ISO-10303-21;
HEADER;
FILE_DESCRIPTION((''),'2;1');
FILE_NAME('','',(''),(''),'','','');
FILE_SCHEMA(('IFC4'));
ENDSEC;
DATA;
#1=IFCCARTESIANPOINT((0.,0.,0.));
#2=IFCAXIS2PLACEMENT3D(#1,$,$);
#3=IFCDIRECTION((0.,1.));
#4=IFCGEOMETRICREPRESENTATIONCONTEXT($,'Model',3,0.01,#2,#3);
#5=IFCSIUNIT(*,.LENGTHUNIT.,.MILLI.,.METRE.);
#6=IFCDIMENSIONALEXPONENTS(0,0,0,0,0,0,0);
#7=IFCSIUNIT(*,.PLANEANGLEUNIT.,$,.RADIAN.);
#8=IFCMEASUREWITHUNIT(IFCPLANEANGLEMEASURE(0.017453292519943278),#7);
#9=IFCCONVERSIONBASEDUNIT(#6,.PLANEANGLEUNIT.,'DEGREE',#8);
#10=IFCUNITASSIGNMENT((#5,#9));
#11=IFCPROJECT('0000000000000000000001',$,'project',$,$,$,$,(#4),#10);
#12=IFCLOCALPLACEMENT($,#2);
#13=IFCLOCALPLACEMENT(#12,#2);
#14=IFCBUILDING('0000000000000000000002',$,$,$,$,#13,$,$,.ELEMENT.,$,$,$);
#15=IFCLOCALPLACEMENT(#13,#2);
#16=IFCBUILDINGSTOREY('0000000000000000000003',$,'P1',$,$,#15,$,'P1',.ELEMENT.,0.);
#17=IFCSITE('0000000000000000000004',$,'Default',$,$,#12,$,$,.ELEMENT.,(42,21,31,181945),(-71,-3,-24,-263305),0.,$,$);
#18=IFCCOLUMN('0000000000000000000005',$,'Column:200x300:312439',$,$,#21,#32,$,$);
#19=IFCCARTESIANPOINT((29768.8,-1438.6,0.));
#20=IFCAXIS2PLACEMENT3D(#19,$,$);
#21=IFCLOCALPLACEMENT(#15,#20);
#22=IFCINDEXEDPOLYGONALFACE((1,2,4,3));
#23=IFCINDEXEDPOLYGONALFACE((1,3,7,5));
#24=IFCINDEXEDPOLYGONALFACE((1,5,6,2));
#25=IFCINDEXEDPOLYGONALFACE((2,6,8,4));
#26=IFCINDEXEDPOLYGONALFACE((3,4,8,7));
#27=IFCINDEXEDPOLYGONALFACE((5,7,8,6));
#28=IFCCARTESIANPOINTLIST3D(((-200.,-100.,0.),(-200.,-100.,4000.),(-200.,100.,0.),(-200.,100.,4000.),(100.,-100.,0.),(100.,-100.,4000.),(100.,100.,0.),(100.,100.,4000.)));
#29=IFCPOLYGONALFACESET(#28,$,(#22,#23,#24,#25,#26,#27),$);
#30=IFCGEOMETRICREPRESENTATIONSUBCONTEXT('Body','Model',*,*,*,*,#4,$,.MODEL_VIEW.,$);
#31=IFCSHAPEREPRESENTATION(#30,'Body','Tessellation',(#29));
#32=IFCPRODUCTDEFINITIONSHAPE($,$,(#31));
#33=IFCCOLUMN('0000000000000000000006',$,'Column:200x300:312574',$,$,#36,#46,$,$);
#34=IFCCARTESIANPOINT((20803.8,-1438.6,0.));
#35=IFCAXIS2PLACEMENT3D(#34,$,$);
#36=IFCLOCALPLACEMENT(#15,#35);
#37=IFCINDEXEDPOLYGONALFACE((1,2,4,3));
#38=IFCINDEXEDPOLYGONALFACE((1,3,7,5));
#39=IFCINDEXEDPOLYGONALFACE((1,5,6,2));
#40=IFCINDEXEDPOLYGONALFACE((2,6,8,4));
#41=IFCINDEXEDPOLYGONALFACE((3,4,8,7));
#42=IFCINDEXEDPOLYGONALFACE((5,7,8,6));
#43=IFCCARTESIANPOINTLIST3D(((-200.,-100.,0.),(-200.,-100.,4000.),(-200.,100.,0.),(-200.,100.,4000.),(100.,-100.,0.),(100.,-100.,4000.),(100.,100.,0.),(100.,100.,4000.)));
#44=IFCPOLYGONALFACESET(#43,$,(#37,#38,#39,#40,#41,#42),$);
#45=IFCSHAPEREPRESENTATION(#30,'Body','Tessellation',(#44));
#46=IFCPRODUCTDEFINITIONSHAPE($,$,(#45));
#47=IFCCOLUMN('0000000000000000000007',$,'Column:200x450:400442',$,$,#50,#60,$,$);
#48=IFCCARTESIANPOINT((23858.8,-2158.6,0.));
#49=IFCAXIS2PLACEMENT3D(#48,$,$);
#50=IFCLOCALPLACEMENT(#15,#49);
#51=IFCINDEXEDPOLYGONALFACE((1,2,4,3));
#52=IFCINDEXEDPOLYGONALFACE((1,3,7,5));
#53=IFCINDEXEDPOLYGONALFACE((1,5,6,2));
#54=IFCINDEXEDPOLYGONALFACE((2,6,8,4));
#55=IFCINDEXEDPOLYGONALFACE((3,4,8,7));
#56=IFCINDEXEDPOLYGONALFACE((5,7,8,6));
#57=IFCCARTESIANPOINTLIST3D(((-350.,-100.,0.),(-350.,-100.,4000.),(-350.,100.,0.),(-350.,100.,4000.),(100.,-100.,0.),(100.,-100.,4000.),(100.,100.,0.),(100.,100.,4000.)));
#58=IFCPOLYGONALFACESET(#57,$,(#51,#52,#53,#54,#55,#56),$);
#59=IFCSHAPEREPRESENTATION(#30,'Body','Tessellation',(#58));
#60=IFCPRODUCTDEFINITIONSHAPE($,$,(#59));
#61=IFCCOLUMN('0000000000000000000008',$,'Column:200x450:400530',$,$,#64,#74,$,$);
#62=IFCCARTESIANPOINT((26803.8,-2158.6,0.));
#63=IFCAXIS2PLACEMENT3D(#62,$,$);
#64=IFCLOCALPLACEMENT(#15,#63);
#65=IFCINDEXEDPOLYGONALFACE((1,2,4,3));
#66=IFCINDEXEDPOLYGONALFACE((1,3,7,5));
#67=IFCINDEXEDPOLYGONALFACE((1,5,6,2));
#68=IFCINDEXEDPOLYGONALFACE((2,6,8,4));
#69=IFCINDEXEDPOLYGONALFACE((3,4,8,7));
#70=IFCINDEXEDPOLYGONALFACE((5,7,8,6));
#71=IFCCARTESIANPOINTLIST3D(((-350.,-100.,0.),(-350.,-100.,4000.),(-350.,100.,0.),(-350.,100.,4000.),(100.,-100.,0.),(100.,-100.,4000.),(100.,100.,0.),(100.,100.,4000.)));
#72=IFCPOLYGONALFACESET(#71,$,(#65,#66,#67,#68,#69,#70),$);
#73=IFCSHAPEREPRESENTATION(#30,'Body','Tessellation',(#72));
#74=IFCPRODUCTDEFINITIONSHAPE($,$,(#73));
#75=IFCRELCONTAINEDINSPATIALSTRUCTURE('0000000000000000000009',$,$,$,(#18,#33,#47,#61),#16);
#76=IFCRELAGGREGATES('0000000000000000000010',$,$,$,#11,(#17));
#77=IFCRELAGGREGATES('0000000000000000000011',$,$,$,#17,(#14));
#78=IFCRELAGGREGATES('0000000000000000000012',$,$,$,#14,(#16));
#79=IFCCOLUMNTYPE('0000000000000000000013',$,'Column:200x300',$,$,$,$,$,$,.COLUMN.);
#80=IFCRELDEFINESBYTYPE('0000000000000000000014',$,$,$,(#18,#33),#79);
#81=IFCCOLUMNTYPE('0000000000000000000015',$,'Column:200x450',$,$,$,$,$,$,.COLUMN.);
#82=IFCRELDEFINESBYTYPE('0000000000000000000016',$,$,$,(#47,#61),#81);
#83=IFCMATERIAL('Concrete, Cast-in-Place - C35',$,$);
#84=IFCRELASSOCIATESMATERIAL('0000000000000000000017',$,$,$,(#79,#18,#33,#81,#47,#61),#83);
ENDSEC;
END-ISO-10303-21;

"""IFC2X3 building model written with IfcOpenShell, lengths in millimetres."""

from ifc_helpers import new_model, entity, si_unit, converted_unit, direction, frame, origin, origin_2d_with_axis, place, context, subcontext, project, spatial, rectangle, extrude, source, transform, mapped, material, type_object, type_shapes, element, save


model = new_model("IFC2X3")

# Units and contexts
model_context = context("Model", 3, precision=0.01, world=origin(), true_north=direction((0.0, 1.0)))
body_context = subcontext(model_context, "Body", "Model", "MODEL_VIEW")
ifc_project = project(units=[si_unit("LENGTHUNIT", "METRE", prefix="MILLI"), converted_unit("PLANEANGLEUNIT", "DEGREE", entity("IfcPlaneAngleMeasure", 0.017453292519943278), si_unit("PLANEANGLEUNIT", "RADIAN"), dimensions=[0, 0, 0, 0, 0, 0, 0])], contexts=[model_context])

# Site, building, storey
site_placement = place(None, origin())
site = spatial("IfcSite", under=ifc_project, at=site_placement, Name="Default", CompositionType="ELEMENT", RefLatitude=(42, 21, 31, 181945), RefLongitude=(-71, -3, -24, -263305), RefElevation=0.0)
building_placement = place(site_placement, origin())
building = spatial("IfcBuilding", under=site, at=building_placement, CompositionType="ELEMENT")
storey_placement = place(building_placement, origin())
storey = spatial("IfcBuildingStorey", under=building, at=storey_placement, Name="P1", LongName="P1", CompositionType="ELEMENT", Elevation=0.0)

# Columns
ifc_material_1 = material(Name="Concrete, Cast-in-Place - C35")
column_type_1 = type_object("IfcColumnType", Name="Column:200x300", PredefinedType="COLUMN", material=ifc_material_1)
shared_shape_1 = source(origin(), body_context, "Body", "SweptSolid", [
    extrude(rectangle(XDim=300.0, YDim=200.0, at=origin_2d_with_axis()), frame((-50.0, 0.0, 0.0), z_axis=(0.0, 0.0, 1.0), x_axis=(-1.0, 0.0, 0.0)), (0.0, 0.0, 1.0), 4000.0),
])
type_shapes(column_type_1, [shared_shape_1])
for number, where, name in (
    (1, (29768.8, -1438.6, 0.0), "Column:200x300:312439"),
    (2, (20803.8, -1438.6, 0.0), "Column:200x300:312574"),
):
    element("IfcColumn", number, at=place(storey_placement, frame(where)), inside=storey, type_object=column_type_1, material=ifc_material_1, Name=name, context=body_context, shape_type="MappedRepresentation", body=[
        mapped(shared_shape_1, transform((0.0, 0.0, 0.0), scale=1.0)),
    ])
column_type_2 = type_object("IfcColumnType", Name="Column:200x450", PredefinedType="COLUMN", material=ifc_material_1)
shared_shape_2 = source(origin(), body_context, "Body", "SweptSolid", [
    extrude(rectangle(XDim=450.0, YDim=200.0, at=origin_2d_with_axis()), frame((-125.0, 0.0, 0.0), z_axis=(0.0, 0.0, 1.0), x_axis=(-1.0, 0.0, 0.0)), (0.0, 0.0, 1.0), 4000.0),
])
type_shapes(column_type_2, [shared_shape_2])
for number, where, name in (
    (3, (23858.8, -2158.6, 0.0), "Column:200x450:400442"),
    (4, (26803.8, -2158.6, 0.0), "Column:200x450:400530"),
):
    element("IfcColumn", number, at=place(storey_placement, frame(where)), inside=storey, type_object=column_type_2, material=ifc_material_1, Name=name, context=body_context, shape_type="MappedRepresentation", body=[
        mapped(shared_shape_2, transform((0.0, 0.0, 0.0), scale=1.0)),
    ])

save(model, "model.ifc")
